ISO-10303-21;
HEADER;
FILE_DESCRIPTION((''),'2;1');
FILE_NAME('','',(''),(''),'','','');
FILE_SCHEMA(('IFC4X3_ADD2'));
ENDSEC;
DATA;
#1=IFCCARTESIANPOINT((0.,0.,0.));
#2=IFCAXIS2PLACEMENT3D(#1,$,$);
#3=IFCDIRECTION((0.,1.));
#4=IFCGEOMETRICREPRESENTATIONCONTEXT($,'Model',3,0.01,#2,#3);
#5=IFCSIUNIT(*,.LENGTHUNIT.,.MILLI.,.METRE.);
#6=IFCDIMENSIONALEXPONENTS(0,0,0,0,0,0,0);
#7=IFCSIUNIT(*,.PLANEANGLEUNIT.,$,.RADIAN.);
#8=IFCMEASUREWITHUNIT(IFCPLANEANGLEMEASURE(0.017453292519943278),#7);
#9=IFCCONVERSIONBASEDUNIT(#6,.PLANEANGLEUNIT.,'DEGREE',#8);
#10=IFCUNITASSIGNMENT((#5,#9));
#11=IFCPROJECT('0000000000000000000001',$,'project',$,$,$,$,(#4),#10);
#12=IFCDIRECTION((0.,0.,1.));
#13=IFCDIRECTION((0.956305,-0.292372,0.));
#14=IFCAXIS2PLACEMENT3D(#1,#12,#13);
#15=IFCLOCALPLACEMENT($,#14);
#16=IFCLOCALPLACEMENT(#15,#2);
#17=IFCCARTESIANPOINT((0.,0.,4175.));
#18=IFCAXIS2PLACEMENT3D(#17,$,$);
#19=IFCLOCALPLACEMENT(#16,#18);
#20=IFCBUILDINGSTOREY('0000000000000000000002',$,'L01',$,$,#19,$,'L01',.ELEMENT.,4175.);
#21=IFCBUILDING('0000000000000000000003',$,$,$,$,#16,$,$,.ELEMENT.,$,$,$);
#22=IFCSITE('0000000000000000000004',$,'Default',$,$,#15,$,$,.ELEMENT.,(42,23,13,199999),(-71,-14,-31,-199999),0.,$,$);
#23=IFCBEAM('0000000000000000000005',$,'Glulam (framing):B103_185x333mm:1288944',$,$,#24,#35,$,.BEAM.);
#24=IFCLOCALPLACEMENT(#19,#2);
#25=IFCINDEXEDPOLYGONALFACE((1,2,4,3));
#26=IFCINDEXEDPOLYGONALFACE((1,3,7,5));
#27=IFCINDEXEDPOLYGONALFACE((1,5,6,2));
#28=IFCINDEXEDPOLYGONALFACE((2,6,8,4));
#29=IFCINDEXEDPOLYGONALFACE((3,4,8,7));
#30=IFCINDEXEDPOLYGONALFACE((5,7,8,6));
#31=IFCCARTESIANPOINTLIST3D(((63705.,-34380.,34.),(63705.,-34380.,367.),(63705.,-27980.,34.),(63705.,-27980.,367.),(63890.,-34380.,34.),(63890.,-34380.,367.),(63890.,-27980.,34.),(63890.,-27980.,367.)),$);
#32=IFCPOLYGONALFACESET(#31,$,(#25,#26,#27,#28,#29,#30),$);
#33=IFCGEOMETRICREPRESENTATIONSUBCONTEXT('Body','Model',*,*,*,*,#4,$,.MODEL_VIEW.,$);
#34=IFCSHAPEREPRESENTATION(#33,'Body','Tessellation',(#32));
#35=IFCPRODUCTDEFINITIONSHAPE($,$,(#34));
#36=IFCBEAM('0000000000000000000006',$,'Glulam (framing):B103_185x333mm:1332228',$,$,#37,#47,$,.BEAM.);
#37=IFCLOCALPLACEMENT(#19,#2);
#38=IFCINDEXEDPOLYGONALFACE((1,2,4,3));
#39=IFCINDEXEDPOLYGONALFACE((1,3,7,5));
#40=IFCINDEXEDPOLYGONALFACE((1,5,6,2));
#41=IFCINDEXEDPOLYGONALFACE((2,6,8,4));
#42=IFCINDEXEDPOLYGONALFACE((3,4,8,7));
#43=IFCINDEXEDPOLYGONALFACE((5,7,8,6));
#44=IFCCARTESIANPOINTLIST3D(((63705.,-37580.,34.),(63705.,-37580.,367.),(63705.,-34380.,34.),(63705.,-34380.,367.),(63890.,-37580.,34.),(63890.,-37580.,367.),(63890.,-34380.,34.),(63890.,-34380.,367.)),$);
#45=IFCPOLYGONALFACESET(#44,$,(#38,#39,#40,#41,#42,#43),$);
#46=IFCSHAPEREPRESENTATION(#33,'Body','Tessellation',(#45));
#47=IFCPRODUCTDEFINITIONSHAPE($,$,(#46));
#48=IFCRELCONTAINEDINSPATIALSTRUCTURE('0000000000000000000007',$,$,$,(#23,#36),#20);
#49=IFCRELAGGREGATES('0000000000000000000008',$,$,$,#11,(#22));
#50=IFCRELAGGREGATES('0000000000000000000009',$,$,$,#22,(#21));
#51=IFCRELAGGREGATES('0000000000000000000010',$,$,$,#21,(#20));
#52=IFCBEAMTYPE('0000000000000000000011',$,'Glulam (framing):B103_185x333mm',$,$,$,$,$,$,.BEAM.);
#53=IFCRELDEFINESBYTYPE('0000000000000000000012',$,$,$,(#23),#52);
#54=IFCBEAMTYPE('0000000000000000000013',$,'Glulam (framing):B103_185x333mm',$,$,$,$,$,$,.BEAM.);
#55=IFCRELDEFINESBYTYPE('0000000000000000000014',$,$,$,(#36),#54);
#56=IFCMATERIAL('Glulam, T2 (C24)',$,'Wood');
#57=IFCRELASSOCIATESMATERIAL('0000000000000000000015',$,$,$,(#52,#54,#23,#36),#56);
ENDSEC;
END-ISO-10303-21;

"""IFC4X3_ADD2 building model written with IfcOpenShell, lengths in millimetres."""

from ifc_helpers import new_model, entity, si_unit, converted_unit, direction, frame, origin, origin_2d_with_axis, place, context, subcontext, project, spatial, rectangle, extrude, source, transform, mapped, material, material_profile, profile_set, profile_usage, type_object, type_shapes, element, save


model = new_model("IFC4X3_ADD2")

# Units and contexts
model_context = context("Model", 3, precision=0.01, world=origin(), true_north=direction((0.0, 1.0)))
body_context = subcontext(model_context, "Body", "Model", "MODEL_VIEW")
ifc_project = project(units=[si_unit("LENGTHUNIT", "METRE", prefix="MILLI"), converted_unit("PLANEANGLEUNIT", "DEGREE", entity("IfcPlaneAngleMeasure", 0.017453292519943278), si_unit("PLANEANGLEUNIT", "RADIAN"), dimensions=[0, 0, 0, 0, 0, 0, 0])], contexts=[model_context])

# Site, building, storey
site_placement = place(None, frame((0.0, 0.0, 0.0), z_axis=(0.0, 0.0, 1.0), x_axis=(0.956305, -0.292372, 0.0)))
site = spatial("IfcSite", under=ifc_project, at=site_placement, Name="Default", CompositionType="ELEMENT", RefLatitude=(42, 23, 13, 199999), RefLongitude=(-71, -14, -31, -199999), RefElevation=0.0)
building_placement = place(site_placement, origin())
building = spatial("IfcBuilding", under=site, at=building_placement, CompositionType="ELEMENT")
storey_placement = place(building_placement, frame((0.0, 0.0, 4175.0)))
storey = spatial("IfcBuildingStorey", under=building, at=storey_placement, Name="L01", LongName="L01", CompositionType="ELEMENT", Elevation=4175.0)

# Beams
ifc_material_1 = material(Name="Glulam, T2 (C24)", Category="Wood")
ifc_material_profile_1 = material_profile(ifc_material_1, rectangle(XDim=3200.0, YDim=185.0, at=origin_2d_with_axis()), Name="B103_185x333mm")
ifc_profile_set_1 = profile_set([ifc_material_profile_1], Name="B103_185x333mm")
ifc_profile_usage_1 = profile_usage(ifc_profile_set_1, cardinal=8)
beam_type_1 = type_object("IfcBeamType", Name="Glulam (framing):B103_185x333mm", PredefinedType="BEAM", material=ifc_profile_set_1)
shared_shape_1 = source(origin(), body_context, "Body", "SweptSolid", [
    extrude(rectangle(XDim=185.0, YDim=6400.0, at=origin_2d_with_axis()), frame((-760.0, 0.0, -166.5), z_axis=(0.0, 0.0, 1.0), x_axis=(0.0, 1.0, 0.0)), (0.0, 0.0, 1.0), 333.0),
])
type_shapes(beam_type_1, [shared_shape_1])
beam_1_placement = place(storey_placement, frame((63797.5, -31940.0, 200.5), z_axis=(0.0, 0.0, 1.0), x_axis=(0.0, -1.0, 0.0)))
element("IfcBeam", 1, at=beam_1_placement, inside=storey, type_object=beam_type_1, material=ifc_profile_usage_1, Name="Glulam (framing):B103_185x333mm:1288944", PredefinedType="BEAM", context=body_context, shape_type="MappedRepresentation", body=[
    mapped(shared_shape_1, transform((0.0, 0.0, 0.0), scale=1.0)),
])
beam_type_2 = type_object("IfcBeamType", Name="Glulam (framing):B103_185x333mm", PredefinedType="BEAM", material=ifc_profile_set_1)
shared_shape_2 = source(origin(), body_context, "Body", "SweptSolid", [
    extrude(rectangle(XDim=185.0, YDim=3200.0, at=origin_2d_with_axis()), frame((840.0, 0.0, -166.5), z_axis=(0.0, 0.0, 1.0), x_axis=(0.0, 1.0, 0.0)), (0.0, 0.0, 1.0), 333.0),
])
type_shapes(beam_type_2, [shared_shape_2])
beam_2_placement = place(storey_placement, frame((63797.5, -35140.0, 200.5), z_axis=(0.0, 0.0, 1.0), x_axis=(0.0, -1.0, 0.0)))
element("IfcBeam", 2, at=beam_2_placement, inside=storey, type_object=beam_type_2, material=ifc_profile_usage_1, Name="Glulam (framing):B103_185x333mm:1332228", PredefinedType="BEAM", context=body_context, shape_type="MappedRepresentation", body=[
    mapped(shared_shape_2, transform((0.0, 0.0, 0.0), scale=1.0)),
])

save(model, "model.ifc")
